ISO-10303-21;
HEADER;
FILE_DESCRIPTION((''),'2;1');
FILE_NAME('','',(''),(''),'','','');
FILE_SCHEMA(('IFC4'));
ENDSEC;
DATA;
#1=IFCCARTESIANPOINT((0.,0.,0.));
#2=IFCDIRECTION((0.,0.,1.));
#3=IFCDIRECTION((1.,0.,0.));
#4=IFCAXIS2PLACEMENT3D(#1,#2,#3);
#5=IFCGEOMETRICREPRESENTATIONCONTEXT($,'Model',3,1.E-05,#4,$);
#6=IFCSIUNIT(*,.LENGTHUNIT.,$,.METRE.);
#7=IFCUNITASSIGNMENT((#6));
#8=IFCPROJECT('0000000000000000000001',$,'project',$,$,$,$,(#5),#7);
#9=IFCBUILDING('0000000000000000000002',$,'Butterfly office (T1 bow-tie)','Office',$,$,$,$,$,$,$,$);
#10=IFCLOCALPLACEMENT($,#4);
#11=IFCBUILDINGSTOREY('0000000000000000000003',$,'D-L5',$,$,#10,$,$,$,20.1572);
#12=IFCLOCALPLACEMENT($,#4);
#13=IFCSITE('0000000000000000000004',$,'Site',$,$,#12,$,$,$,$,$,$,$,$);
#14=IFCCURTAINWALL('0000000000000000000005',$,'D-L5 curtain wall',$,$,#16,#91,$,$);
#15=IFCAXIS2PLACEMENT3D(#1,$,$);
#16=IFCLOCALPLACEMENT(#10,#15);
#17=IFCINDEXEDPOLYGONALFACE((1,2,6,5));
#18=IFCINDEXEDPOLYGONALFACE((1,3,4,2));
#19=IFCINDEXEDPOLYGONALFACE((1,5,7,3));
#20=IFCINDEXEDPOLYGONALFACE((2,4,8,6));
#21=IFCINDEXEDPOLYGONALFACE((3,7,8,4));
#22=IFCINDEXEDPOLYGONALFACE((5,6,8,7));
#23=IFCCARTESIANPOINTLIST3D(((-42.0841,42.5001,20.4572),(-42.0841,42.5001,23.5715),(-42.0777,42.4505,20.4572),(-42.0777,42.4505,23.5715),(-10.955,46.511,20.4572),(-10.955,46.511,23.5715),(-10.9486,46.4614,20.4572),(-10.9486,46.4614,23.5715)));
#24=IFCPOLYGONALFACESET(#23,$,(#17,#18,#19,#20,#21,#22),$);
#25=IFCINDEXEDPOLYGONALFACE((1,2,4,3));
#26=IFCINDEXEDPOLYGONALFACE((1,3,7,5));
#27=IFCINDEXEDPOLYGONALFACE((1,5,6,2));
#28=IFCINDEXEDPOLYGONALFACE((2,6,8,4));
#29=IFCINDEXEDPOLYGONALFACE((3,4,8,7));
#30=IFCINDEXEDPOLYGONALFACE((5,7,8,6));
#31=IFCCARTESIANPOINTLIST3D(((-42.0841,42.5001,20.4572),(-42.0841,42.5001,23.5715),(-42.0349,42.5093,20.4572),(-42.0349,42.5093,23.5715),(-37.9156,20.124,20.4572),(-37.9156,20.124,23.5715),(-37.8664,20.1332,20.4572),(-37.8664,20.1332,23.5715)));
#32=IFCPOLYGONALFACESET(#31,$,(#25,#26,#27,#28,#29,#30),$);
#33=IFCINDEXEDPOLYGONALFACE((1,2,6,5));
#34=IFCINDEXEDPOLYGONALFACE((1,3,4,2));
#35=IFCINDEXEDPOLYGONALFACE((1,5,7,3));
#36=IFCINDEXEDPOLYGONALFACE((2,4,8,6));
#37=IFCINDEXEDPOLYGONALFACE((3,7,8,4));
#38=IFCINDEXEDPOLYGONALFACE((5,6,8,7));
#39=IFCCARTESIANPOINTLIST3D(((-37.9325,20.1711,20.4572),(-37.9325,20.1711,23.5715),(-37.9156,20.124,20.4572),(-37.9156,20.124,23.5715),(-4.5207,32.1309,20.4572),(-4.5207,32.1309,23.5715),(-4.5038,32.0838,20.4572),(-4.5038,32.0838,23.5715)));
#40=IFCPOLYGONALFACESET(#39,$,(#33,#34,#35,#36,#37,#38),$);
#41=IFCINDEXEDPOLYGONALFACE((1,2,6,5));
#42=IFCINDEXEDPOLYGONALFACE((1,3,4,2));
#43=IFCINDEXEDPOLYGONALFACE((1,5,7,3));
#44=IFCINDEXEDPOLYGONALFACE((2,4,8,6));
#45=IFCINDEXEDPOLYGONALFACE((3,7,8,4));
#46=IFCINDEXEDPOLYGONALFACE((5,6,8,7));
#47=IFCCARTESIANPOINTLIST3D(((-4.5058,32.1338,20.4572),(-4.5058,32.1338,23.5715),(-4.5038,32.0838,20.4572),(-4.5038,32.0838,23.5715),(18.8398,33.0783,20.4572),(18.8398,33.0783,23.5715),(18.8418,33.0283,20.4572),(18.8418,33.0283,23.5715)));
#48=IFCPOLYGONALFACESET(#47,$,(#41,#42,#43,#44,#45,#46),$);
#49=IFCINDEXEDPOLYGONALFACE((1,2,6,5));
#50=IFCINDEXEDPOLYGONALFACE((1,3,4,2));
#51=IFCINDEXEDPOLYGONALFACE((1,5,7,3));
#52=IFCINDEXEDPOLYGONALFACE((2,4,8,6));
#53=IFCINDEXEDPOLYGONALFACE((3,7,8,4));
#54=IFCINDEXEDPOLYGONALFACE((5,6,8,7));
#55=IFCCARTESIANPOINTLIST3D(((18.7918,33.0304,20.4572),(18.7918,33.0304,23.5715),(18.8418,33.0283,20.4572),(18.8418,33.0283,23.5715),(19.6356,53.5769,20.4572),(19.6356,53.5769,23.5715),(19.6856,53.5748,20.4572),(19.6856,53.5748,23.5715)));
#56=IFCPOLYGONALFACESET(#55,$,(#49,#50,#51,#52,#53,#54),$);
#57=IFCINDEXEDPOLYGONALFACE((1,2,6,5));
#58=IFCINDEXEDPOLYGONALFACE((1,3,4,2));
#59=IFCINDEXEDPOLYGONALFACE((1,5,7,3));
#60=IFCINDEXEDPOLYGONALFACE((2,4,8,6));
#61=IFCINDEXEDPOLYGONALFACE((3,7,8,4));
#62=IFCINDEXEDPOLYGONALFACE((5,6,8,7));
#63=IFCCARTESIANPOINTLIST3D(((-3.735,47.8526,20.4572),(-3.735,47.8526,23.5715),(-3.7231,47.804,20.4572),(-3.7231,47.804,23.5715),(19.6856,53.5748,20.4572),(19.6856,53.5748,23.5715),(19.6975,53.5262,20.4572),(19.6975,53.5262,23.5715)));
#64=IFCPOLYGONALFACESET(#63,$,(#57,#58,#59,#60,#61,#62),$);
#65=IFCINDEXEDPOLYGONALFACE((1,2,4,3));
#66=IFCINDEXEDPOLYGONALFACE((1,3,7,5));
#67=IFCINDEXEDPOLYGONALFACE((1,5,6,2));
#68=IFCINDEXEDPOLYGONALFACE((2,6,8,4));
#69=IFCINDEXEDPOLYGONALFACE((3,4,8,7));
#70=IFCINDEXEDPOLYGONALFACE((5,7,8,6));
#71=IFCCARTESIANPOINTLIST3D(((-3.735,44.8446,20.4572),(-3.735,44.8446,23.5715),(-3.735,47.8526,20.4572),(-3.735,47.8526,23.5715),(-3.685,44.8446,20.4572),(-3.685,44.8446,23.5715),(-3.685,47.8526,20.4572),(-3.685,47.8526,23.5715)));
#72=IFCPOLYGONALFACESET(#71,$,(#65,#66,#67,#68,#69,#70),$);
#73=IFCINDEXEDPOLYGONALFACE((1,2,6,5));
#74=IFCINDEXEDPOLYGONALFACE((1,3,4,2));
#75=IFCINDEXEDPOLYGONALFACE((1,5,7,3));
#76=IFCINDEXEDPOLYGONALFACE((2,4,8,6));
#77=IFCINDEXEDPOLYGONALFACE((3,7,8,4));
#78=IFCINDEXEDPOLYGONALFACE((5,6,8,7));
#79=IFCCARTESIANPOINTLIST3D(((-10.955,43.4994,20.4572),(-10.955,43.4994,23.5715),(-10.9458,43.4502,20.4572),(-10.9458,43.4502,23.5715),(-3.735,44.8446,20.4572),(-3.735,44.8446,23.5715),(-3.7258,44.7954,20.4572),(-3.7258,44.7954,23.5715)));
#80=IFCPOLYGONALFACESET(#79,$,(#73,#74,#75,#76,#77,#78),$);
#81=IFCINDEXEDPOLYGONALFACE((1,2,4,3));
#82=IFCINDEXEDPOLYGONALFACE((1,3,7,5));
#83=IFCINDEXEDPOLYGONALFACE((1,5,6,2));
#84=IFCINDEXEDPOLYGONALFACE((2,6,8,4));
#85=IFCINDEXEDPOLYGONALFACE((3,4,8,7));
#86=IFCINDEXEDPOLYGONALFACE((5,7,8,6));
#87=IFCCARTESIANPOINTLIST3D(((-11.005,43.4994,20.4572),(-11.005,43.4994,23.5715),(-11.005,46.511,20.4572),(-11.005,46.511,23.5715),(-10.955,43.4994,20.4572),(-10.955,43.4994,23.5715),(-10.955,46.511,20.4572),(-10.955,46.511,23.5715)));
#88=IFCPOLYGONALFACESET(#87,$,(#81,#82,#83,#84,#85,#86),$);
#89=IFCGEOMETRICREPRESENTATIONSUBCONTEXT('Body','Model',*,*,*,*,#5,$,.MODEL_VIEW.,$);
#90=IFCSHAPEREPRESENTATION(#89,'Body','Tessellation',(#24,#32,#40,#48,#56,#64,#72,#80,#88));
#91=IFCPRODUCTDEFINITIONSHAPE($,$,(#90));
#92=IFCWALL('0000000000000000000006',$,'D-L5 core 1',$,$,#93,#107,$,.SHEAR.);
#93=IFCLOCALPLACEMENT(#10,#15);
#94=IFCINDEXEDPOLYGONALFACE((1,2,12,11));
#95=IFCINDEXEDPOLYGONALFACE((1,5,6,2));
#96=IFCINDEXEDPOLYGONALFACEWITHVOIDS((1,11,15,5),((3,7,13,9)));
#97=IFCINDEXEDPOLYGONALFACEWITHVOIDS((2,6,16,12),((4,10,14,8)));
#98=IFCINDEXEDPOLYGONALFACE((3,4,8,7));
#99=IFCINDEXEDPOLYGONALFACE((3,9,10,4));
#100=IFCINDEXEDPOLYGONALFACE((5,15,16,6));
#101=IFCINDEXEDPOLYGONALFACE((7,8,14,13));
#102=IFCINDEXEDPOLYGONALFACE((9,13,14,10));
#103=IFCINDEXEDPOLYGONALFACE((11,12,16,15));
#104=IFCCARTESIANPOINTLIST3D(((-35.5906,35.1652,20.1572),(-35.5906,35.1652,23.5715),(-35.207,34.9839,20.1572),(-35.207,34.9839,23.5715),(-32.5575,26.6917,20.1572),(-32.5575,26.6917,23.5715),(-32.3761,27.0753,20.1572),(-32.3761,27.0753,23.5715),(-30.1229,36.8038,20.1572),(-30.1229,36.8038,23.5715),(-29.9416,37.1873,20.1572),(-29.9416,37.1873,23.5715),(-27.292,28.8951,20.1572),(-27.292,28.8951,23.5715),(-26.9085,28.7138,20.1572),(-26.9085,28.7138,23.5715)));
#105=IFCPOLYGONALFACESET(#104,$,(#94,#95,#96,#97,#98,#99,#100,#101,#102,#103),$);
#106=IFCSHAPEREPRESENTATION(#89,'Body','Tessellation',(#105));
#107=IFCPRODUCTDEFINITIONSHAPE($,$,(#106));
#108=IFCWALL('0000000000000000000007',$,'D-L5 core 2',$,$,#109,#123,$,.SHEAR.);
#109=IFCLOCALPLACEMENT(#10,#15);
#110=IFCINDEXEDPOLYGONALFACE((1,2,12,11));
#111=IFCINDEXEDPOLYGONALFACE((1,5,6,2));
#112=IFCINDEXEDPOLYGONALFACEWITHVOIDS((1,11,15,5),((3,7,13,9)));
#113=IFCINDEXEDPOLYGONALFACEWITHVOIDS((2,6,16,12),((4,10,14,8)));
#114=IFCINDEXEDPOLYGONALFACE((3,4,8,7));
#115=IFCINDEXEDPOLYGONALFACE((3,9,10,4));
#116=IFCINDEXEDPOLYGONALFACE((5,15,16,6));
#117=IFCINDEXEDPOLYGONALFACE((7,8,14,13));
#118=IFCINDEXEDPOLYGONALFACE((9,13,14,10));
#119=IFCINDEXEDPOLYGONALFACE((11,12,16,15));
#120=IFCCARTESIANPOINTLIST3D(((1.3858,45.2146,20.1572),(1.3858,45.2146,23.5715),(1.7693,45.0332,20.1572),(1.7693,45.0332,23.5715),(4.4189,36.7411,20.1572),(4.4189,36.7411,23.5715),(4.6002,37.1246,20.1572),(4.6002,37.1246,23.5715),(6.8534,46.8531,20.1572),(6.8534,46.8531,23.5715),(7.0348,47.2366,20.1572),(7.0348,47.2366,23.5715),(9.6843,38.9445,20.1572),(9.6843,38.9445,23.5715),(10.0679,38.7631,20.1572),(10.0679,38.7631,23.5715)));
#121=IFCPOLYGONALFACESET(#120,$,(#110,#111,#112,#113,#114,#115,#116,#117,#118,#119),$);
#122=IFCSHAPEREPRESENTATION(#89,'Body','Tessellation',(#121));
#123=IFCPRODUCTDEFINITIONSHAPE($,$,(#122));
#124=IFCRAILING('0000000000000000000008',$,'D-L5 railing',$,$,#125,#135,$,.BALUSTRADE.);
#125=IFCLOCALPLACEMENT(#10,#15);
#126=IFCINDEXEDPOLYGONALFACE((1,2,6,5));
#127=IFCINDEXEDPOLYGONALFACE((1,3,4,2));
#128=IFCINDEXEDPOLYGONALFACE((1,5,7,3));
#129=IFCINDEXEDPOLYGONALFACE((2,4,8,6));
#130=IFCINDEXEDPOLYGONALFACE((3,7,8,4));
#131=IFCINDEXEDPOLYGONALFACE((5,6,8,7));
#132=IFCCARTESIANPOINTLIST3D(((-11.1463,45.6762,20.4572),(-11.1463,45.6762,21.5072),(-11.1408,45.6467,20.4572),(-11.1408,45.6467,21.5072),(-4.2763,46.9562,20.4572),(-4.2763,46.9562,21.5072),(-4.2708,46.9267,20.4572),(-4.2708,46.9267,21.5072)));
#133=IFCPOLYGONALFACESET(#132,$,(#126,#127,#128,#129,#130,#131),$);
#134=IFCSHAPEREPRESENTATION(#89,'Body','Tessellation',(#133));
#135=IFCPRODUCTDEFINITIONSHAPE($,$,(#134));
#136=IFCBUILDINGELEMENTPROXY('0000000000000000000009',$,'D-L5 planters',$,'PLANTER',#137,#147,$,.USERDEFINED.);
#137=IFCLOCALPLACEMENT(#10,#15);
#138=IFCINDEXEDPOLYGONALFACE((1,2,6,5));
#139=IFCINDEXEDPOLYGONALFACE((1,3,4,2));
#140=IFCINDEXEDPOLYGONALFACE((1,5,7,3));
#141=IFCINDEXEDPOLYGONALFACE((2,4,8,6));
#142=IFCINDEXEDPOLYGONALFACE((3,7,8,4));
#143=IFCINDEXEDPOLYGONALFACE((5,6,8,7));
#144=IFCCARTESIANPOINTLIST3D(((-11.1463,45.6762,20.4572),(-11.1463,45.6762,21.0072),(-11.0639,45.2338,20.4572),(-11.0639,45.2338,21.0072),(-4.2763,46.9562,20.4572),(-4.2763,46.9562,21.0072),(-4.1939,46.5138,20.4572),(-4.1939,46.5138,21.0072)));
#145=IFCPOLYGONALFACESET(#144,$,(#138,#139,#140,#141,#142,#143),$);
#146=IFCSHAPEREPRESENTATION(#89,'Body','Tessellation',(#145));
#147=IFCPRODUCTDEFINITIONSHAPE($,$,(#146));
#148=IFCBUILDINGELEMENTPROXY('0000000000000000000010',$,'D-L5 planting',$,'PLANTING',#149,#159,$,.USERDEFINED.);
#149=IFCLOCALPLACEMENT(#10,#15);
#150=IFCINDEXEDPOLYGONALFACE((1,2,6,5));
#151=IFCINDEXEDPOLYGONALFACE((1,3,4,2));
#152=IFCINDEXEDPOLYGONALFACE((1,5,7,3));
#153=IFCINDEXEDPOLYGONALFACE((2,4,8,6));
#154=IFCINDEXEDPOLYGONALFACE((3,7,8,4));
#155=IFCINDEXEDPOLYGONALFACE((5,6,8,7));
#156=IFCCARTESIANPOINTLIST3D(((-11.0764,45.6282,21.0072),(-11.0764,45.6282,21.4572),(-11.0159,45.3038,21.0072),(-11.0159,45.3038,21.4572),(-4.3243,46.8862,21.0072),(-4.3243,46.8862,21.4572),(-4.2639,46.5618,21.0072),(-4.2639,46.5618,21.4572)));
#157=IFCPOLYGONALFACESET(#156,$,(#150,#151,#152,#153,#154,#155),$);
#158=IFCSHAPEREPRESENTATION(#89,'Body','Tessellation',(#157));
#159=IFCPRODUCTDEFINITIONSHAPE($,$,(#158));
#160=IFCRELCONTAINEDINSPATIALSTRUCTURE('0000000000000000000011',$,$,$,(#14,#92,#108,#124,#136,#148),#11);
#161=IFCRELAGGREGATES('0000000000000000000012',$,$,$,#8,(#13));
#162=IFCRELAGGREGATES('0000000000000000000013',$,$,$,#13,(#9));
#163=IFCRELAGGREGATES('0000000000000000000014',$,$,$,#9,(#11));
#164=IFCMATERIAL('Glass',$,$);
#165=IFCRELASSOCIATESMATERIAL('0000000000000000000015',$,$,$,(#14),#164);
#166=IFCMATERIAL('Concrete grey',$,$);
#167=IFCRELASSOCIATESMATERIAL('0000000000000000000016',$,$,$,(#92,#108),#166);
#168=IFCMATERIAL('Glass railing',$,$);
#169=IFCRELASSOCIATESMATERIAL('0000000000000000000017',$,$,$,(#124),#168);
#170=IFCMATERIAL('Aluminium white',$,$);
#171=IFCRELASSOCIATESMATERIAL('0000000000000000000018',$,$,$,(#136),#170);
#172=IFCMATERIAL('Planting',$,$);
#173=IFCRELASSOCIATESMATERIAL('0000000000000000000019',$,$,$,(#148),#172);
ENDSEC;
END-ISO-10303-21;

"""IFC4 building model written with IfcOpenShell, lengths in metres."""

from ifc_helpers import new_model, si_unit, frame, origin_with_axes, place, context, subcontext, project, spatial, polyline, outline, extrude, material, element, save


model = new_model("IFC4")

# Units and contexts
model_context = context("Model", 3, precision=1e-05, world=origin_with_axes())
body_context = subcontext(model_context, "Body", "Model", "MODEL_VIEW")
ifc_project = project(units=[si_unit("LENGTHUNIT", "METRE")], contexts=[model_context])

# Site, building, storey
site_placement = place(None, origin_with_axes())
site = spatial("IfcSite", under=ifc_project, at=site_placement, Name="Site")
building = spatial("IfcBuilding", under=site, Name="Butterfly office (T1 bow-tie)", Description="Office")
storey_placement = place(None, origin_with_axes())
storey = spatial("IfcBuildingStorey", under=building, at=storey_placement, Name="D-L5", Elevation=20.1572)

# Shared definitions
ifc_material_1 = material(Name="Concrete grey")

# Shared definitions
ifc_material_2 = material(Name="Aluminium white")

# Curtain wall
ifc_material_3 = material(Name="Glass")
curtain_wall_placement = place(storey_placement, origin_with_axes())
element("IfcCurtainWall", 1, at=curtain_wall_placement, inside=storey, material=ifc_material_3, Name="D-L5 curtain wall", context=body_context, shape_type="SweptSolid", body=[
    extrude(outline(polyline([(-10.955, 46.511), (-42.0841, 42.5001), (-42.0777, 42.4505), (-10.9486, 46.4614), (-10.955, 46.511)])), frame((0.0, 0.0, 20.4572), z_axis=(0.0, 0.0, 1.0), x_axis=(1.0, 0.0, 0.0)), (0.0, 0.0, 1.0), 3.1143),
    extrude(outline(polyline([(-42.0841, 42.5001), (-37.9156, 20.124), (-37.8664, 20.1332), (-42.0349, 42.5093), (-42.0841, 42.5001)])), frame((0.0, 0.0, 20.4572), z_axis=(0.0, 0.0, 1.0), x_axis=(1.0, 0.0, 0.0)), (0.0, 0.0, 1.0), 3.1143),
    extrude(outline(polyline([(-37.9156, 20.124), (-4.5038, 32.0838), (-4.5207, 32.1309), (-37.9325, 20.1711), (-37.9156, 20.124)])), frame((0.0, 0.0, 20.4572), z_axis=(0.0, 0.0, 1.0), x_axis=(1.0, 0.0, 0.0)), (0.0, 0.0, 1.0), 3.1143),
    extrude(outline(polyline([(-4.5038, 32.0838), (18.8418, 33.0283), (18.8398, 33.0783), (-4.5058, 32.1338), (-4.5038, 32.0838)])), frame((0.0, 0.0, 20.4572), z_axis=(0.0, 0.0, 1.0), x_axis=(1.0, 0.0, 0.0)), (0.0, 0.0, 1.0), 3.1143),
    extrude(outline(polyline([(18.8418, 33.0283), (19.6856, 53.5748), (19.6356, 53.5769), (18.7918, 33.0304), (18.8418, 33.0283)])), frame((0.0, 0.0, 20.4572), z_axis=(0.0, 0.0, 1.0), x_axis=(1.0, 0.0, 0.0)), (0.0, 0.0, 1.0), 3.1143),
    extrude(outline(polyline([(19.6856, 53.5748), (-3.735, 47.8526), (-3.7231, 47.804), (19.6975, 53.5262), (19.6856, 53.5748)])), frame((0.0, 0.0, 20.4572), z_axis=(0.0, 0.0, 1.0), x_axis=(1.0, 0.0, 0.0)), (0.0, 0.0, 1.0), 3.1143),
    extrude(outline(polyline([(-3.735, 47.8526), (-3.735, 44.8446), (-3.685, 44.8446), (-3.685, 47.8526), (-3.735, 47.8526)])), frame((0.0, 0.0, 20.4572), z_axis=(0.0, 0.0, 1.0), x_axis=(1.0, 0.0, 0.0)), (0.0, 0.0, 1.0), 3.1143),
    extrude(outline(polyline([(-3.735, 44.8446), (-10.955, 43.4994), (-10.9458, 43.4502), (-3.7258, 44.7954), (-3.735, 44.8446)])), frame((0.0, 0.0, 20.4572), z_axis=(0.0, 0.0, 1.0), x_axis=(1.0, 0.0, 0.0)), (0.0, 0.0, 1.0), 3.1143),
    extrude(outline(polyline([(-10.955, 43.4994), (-10.955, 46.511), (-11.005, 46.511), (-11.005, 43.4994), (-10.955, 43.4994)])), frame((0.0, 0.0, 20.4572), z_axis=(0.0, 0.0, 1.0), x_axis=(1.0, 0.0, 0.0)), (0.0, 0.0, 1.0), 3.1143),
])

# Walls
wall_1_placement = place(storey_placement, origin_with_axes())
element("IfcWall", 2, at=wall_1_placement, inside=storey, material=ifc_material_1, Name="D-L5 core 1", PredefinedType="SHEAR", context=body_context, shape_type="SweptSolid", body=[
    extrude(outline(polyline([(-32.5575, 26.6917), (-26.9085, 28.7138), (-29.9416, 37.1873), (-35.5906, 35.1652), (-32.5575, 26.6917)]), holes=[polyline([(-32.3761, 27.0753), (-27.292, 28.8951), (-30.1229, 36.8038), (-35.207, 34.9839), (-32.3761, 27.0753)])]), frame((0.0, 0.0, 20.1572), z_axis=(0.0, 0.0, 1.0), x_axis=(1.0, 0.0, 0.0)), (0.0, 0.0, 1.0), 3.4143),
])
wall_2_placement = place(storey_placement, origin_with_axes())
element("IfcWall", 3, at=wall_2_placement, inside=storey, material=ifc_material_1, Name="D-L5 core 2", PredefinedType="SHEAR", context=body_context, shape_type="SweptSolid", body=[
    extrude(outline(polyline([(4.4189, 36.7411), (10.0679, 38.7631), (7.0348, 47.2366), (1.3858, 45.2146), (4.4189, 36.7411)]), holes=[polyline([(4.6002, 37.1246), (9.6843, 38.9445), (6.8534, 46.8531), (1.7693, 45.0332), (4.6002, 37.1246)])]), frame((0.0, 0.0, 20.1572), z_axis=(0.0, 0.0, 1.0), x_axis=(1.0, 0.0, 0.0)), (0.0, 0.0, 1.0), 3.4143),
])

# Railing
ifc_material_4 = material(Name="Glass railing")
railing_placement = place(storey_placement, origin_with_axes())
element("IfcRailing", 4, at=railing_placement, inside=storey, material=ifc_material_4, Name="D-L5 railing", PredefinedType="BALUSTRADE", context=body_context, shape_type="SweptSolid", body=[
    extrude(outline(polyline([(-4.2763, 46.9562), (-11.1463, 45.6762), (-11.1408, 45.6467), (-4.2708, 46.9267), (-4.2763, 46.9562)])), frame((0.0, 0.0, 20.4572), z_axis=(0.0, 0.0, 1.0), x_axis=(1.0, 0.0, 0.0)), (0.0, 0.0, 1.0), 1.05),
])

# Building element proxies
proxy_1_placement = place(storey_placement, origin_with_axes())
element("IfcBuildingElementProxy", 5, at=proxy_1_placement, inside=storey, material=ifc_material_2, Name="D-L5 planters", ObjectType="PLANTER", PredefinedType="USERDEFINED", context=body_context, shape_type="SweptSolid", body=[
    extrude(outline(polyline([(-4.2763, 46.9562), (-11.1463, 45.6762), (-11.0639, 45.2338), (-4.1939, 46.5138), (-4.2763, 46.9562)])), frame((0.0, 0.0, 20.4572), z_axis=(0.0, 0.0, 1.0), x_axis=(1.0, 0.0, 0.0)), (0.0, 0.0, 1.0), 0.55),
])
ifc_material_5 = material(Name="Planting")
proxy_2_placement = place(storey_placement, origin_with_axes())
element("IfcBuildingElementProxy", 6, at=proxy_2_placement, inside=storey, material=ifc_material_5, Name="D-L5 planting", ObjectType="PLANTING", PredefinedType="USERDEFINED", context=body_context, shape_type="SweptSolid", body=[
    extrude(outline(polyline([(-4.3243, 46.8862), (-11.0764, 45.6282), (-11.0159, 45.3038), (-4.2639, 46.5618), (-4.3243, 46.8862)])), frame((0.0, 0.0, 21.0072), z_axis=(0.0, 0.0, 1.0), x_axis=(1.0, 0.0, 0.0)), (0.0, 0.0, 1.0), 0.45),
])

save(model, "model.ifc")
